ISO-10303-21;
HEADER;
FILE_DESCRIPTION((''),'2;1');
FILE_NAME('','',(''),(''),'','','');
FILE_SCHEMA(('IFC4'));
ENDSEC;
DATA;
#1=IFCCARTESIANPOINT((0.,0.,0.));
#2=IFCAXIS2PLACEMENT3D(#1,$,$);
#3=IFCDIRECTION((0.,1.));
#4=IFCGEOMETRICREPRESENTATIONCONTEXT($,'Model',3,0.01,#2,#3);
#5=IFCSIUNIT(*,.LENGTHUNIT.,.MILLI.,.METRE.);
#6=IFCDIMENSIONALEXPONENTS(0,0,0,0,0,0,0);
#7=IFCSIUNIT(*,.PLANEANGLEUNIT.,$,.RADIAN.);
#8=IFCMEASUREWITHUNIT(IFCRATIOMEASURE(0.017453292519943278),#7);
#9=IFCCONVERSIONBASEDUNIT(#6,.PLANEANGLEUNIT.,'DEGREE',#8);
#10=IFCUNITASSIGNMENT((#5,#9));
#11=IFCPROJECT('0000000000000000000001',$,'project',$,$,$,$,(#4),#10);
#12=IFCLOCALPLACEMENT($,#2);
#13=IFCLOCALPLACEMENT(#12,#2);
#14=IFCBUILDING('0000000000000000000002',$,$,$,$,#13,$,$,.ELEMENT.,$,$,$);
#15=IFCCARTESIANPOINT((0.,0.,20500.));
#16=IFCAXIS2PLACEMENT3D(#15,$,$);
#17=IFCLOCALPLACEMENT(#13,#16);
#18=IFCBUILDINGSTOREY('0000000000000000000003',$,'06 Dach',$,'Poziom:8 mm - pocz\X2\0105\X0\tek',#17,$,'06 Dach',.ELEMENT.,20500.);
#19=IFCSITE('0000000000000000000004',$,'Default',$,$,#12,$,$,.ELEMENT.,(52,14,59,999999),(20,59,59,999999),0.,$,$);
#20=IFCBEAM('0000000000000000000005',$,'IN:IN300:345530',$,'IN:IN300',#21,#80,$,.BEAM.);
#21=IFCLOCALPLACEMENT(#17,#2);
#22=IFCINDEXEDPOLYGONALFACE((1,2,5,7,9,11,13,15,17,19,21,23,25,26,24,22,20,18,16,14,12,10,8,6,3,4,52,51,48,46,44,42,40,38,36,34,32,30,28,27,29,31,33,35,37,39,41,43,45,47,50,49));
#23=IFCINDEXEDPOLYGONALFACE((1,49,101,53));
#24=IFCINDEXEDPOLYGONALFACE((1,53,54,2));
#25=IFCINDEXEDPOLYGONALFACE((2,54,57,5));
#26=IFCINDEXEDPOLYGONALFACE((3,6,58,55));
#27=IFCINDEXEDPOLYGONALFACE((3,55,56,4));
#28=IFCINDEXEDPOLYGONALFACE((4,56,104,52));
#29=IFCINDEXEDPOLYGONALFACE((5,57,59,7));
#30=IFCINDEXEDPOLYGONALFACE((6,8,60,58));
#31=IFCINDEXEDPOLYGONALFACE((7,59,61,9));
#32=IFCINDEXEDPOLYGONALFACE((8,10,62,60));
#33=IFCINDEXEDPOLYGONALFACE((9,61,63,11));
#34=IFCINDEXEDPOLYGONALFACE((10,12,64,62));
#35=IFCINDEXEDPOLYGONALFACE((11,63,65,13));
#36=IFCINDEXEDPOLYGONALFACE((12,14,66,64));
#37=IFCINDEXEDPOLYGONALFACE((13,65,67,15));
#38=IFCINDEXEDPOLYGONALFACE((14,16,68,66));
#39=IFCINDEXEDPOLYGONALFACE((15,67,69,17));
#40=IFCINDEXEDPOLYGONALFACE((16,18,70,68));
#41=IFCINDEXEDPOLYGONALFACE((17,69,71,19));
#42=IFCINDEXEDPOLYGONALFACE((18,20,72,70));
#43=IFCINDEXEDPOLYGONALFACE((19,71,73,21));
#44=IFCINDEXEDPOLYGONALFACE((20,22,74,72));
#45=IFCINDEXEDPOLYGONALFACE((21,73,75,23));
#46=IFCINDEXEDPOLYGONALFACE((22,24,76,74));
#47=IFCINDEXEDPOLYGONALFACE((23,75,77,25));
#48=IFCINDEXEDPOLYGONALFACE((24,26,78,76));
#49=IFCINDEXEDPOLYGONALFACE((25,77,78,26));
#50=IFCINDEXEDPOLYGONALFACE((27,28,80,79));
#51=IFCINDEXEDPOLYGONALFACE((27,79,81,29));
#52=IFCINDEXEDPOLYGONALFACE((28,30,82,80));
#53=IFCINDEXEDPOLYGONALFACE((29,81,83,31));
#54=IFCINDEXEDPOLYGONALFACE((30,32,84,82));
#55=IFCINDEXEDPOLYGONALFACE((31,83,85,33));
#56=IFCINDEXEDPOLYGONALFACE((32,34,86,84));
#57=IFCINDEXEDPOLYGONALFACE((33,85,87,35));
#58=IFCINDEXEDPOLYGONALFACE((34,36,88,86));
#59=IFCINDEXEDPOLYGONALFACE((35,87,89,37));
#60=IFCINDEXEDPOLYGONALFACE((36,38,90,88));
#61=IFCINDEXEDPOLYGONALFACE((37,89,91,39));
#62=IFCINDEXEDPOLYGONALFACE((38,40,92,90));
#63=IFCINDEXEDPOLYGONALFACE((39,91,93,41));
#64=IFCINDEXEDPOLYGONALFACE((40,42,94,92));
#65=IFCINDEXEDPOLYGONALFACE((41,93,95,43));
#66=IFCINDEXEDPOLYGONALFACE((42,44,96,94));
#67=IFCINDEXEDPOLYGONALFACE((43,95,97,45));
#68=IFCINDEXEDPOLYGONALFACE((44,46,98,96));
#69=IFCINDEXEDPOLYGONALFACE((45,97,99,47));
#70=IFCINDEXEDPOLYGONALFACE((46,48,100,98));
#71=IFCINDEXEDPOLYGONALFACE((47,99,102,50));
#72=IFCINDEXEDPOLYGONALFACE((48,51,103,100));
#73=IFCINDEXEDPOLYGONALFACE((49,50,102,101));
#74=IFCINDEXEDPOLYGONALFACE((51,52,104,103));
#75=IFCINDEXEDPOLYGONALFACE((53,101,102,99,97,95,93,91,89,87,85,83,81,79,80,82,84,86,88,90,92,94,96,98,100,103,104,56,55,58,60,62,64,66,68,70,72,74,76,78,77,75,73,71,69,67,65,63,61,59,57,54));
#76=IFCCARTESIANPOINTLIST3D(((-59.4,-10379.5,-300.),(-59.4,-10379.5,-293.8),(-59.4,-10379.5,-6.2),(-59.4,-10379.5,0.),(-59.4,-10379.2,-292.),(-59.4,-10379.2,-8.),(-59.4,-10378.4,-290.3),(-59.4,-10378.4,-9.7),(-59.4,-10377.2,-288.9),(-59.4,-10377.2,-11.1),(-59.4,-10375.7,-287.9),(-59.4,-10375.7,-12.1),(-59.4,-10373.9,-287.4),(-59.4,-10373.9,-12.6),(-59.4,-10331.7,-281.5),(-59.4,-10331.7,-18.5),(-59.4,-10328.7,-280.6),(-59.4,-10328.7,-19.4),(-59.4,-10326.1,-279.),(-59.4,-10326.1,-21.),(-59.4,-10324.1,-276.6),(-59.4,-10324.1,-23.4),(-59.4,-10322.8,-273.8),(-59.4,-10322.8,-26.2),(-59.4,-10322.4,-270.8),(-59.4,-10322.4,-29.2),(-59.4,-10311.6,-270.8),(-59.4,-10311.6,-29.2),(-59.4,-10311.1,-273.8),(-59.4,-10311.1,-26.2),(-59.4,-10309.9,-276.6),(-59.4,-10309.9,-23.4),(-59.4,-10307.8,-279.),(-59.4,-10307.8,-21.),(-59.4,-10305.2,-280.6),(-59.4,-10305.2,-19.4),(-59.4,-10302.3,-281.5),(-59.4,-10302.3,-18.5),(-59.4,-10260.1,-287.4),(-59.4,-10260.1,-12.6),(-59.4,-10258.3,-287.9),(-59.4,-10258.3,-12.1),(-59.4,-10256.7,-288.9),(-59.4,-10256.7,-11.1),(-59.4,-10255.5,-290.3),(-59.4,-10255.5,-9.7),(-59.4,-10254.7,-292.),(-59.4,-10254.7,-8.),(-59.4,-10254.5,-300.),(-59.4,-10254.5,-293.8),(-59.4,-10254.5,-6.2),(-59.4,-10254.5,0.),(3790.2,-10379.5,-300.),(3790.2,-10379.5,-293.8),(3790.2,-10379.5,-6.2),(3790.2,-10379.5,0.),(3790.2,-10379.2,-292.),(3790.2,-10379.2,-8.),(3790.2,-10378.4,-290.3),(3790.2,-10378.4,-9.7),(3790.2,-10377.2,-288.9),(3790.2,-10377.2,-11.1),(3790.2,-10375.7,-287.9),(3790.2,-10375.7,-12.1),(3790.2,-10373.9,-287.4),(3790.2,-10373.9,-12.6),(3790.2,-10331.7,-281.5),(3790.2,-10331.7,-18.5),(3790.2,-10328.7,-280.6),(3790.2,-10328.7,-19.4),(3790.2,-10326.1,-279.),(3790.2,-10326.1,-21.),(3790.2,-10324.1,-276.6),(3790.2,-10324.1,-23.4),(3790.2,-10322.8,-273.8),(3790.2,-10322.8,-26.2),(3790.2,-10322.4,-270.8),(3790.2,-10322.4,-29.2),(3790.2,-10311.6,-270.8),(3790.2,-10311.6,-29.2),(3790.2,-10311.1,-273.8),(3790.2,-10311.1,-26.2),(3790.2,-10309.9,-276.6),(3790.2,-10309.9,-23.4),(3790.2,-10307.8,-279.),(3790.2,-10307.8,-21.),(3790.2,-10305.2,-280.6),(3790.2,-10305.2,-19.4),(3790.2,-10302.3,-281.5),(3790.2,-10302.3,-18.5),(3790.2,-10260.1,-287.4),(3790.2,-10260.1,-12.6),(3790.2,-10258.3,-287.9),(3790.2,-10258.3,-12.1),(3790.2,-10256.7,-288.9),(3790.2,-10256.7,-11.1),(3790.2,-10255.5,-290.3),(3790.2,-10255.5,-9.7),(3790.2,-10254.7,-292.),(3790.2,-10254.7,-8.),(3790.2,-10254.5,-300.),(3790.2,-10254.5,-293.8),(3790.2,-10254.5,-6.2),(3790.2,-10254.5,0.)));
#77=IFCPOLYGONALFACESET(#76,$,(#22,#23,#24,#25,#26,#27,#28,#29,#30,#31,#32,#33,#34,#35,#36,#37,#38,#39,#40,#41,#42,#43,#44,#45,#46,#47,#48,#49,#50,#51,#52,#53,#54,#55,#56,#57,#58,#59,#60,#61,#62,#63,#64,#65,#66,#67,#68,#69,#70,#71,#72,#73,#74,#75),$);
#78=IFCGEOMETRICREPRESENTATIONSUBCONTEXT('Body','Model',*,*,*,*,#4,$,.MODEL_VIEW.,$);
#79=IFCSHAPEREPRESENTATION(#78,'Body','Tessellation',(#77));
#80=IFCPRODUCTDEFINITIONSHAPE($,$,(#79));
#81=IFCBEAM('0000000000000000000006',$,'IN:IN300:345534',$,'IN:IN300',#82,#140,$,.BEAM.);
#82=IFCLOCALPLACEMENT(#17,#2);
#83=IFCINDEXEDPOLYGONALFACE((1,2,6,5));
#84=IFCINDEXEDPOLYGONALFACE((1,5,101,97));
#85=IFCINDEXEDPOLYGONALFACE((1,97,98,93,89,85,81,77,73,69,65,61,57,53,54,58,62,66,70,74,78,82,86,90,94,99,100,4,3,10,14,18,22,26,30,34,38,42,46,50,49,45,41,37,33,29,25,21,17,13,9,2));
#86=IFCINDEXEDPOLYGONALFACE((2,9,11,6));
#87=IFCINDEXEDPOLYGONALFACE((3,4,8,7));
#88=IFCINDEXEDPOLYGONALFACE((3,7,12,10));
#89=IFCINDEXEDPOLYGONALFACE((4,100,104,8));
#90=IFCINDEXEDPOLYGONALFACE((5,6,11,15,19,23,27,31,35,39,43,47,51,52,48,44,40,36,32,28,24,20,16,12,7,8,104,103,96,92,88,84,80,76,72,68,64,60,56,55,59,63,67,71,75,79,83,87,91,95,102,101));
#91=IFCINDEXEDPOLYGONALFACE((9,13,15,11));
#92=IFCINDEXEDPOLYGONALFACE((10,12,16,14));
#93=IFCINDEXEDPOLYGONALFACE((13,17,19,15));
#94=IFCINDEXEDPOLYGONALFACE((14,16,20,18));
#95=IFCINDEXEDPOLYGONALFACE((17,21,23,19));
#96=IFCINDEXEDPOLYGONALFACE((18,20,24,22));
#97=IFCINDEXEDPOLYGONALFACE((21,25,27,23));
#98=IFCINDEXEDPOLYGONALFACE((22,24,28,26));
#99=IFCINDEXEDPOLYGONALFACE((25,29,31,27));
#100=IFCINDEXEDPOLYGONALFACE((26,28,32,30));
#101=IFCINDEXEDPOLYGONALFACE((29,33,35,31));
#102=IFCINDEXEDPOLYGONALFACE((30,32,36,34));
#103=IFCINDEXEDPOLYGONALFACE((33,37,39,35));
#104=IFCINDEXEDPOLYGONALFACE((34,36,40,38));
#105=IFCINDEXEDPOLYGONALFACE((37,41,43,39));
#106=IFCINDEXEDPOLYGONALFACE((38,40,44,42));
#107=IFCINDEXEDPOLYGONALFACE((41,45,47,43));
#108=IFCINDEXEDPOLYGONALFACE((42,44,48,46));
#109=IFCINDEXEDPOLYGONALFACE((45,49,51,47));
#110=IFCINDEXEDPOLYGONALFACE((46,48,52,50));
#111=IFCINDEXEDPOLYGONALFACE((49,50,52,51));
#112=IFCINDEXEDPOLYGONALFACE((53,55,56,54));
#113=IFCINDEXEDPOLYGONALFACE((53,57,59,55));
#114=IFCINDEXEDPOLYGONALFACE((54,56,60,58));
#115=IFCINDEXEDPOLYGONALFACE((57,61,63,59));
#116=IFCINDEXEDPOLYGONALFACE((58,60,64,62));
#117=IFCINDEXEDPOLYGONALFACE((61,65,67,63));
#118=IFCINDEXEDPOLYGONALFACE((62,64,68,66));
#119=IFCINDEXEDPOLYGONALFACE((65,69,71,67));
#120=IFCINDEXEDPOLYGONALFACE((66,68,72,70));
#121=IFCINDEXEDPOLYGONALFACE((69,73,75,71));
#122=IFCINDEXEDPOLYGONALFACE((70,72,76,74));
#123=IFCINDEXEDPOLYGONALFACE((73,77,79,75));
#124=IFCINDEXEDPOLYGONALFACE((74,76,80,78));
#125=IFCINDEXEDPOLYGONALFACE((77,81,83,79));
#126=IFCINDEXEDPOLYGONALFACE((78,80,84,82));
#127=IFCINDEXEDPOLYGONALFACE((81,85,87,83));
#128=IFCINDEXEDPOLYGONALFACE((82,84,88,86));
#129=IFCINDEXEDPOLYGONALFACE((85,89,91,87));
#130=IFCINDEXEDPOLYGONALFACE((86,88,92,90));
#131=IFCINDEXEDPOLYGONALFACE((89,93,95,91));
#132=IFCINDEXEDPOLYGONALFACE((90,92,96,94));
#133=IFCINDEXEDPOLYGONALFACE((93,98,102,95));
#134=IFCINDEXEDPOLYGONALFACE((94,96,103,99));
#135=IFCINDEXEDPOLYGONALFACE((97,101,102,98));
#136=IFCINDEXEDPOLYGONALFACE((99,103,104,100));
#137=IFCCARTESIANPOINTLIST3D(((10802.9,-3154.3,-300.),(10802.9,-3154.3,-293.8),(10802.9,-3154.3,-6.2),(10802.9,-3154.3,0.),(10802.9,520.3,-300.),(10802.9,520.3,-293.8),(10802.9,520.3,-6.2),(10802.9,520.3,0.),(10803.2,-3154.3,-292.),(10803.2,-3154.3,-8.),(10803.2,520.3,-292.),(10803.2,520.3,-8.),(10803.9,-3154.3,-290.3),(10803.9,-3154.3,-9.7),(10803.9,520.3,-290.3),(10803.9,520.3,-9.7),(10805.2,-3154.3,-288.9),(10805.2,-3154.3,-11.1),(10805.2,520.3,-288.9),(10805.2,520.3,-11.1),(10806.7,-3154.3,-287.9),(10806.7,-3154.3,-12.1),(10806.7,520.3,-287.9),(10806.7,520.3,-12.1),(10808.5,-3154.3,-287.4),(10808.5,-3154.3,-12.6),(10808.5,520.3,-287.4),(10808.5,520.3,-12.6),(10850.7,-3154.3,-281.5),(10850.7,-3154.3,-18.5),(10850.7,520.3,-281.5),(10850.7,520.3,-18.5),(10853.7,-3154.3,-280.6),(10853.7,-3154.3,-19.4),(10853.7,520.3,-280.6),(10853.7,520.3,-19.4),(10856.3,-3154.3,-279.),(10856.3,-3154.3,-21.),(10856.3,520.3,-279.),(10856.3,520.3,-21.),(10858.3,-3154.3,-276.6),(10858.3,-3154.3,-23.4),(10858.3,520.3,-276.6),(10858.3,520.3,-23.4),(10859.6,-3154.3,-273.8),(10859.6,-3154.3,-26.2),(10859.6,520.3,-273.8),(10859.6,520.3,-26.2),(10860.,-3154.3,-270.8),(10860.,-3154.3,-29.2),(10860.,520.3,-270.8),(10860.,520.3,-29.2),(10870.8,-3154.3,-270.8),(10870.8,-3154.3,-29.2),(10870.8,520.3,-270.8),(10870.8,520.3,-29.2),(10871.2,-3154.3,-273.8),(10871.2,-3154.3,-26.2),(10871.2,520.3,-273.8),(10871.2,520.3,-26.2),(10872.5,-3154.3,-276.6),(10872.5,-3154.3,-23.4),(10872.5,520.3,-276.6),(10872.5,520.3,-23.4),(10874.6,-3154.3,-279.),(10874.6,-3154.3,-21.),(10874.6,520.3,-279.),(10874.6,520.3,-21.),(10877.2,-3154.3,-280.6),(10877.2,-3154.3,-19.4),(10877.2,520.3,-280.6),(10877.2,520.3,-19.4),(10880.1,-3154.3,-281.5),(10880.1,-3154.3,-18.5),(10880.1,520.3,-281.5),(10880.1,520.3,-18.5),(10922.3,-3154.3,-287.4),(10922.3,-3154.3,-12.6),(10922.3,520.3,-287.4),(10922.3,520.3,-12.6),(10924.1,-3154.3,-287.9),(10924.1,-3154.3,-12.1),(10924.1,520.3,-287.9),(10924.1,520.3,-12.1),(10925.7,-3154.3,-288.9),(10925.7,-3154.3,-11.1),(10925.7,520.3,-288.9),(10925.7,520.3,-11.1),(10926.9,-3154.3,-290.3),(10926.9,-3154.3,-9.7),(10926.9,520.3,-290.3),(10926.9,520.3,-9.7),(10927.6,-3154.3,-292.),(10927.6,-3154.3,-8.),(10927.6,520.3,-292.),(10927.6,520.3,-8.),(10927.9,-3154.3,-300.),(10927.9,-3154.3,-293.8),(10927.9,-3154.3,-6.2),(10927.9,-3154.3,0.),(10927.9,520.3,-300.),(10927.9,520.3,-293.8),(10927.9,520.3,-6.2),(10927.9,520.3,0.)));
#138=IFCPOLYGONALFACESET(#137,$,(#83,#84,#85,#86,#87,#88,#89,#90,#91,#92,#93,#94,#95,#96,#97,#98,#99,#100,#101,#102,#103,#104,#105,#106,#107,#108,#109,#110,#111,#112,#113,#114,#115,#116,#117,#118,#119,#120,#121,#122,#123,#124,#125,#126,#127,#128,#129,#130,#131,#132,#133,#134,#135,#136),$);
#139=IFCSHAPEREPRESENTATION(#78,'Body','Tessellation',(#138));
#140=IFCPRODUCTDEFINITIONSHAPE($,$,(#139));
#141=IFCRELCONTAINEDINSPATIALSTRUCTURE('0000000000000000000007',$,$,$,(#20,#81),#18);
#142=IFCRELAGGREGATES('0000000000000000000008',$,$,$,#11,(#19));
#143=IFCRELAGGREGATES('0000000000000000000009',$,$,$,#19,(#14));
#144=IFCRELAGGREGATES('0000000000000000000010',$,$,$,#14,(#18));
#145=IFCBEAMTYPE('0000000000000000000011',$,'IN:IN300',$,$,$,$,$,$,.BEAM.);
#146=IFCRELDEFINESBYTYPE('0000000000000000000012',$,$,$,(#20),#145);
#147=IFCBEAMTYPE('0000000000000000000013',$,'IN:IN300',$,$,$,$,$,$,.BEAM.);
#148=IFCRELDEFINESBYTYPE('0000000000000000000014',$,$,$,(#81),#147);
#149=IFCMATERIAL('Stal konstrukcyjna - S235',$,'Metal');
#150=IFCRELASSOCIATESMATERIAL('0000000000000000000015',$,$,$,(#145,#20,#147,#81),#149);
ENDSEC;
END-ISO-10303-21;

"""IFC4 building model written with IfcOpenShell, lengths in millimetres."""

from ifc_helpers import new_model, entity, si_unit, converted_unit, direction, frame, origin, place, context, subcontext, project, spatial, line, arc, indexed_curve, outline, extrude, source, transform, mapped, material, type_object, type_shapes, element, save


model = new_model("IFC4")

# Units and contexts
model_context = context("Model", 3, precision=0.01, world=origin(), true_north=direction((0.0, 1.0)))
body_context = subcontext(model_context, "Body", "Model", "MODEL_VIEW")
ifc_project = project(units=[si_unit("LENGTHUNIT", "METRE", prefix="MILLI"), converted_unit("PLANEANGLEUNIT", "DEGREE", entity("IfcRatioMeasure", 0.017453292519943278), si_unit("PLANEANGLEUNIT", "RADIAN"), dimensions=[0, 0, 0, 0, 0, 0, 0])], contexts=[model_context])

# Site, building, storey
site_placement = place(None, origin())
site = spatial("IfcSite", under=ifc_project, at=site_placement, Name="Default", CompositionType="ELEMENT", RefLatitude=(52, 14, 59, 999999), RefLongitude=(20, 59, 59, 999999), RefElevation=0.0)
building_placement = place(site_placement, origin())
building = spatial("IfcBuilding", under=site, at=building_placement, CompositionType="ELEMENT")
storey_placement = place(building_placement, frame((0.0, 0.0, 20500.0)))
storey = spatial("IfcBuildingStorey", under=building, at=storey_placement, Name="06 Dach", ObjectType="Poziom:8 mm - początek", LongName="06 Dach", CompositionType="ELEMENT", Elevation=20500.0)

# Beams
ifc_material_1 = material(Name="Stal konstrukcyjna - S235", Category="Metal")
beam_type_1 = type_object("IfcBeamType", Name="IN:IN300", PredefinedType="BEAM", material=ifc_material_1)
shared_shape_1 = source(origin(), body_context, "Body", "SweptSolid", [
    extrude(outline(indexed_curve([(143.8, -62.5), (150.0, -62.5), (150.0, 62.5), (143.8, 62.5), (139.6, 60.9), (137.4, 56.9), (131.5, 14.7), (127.9, 8.1), (120.8, 5.4), (-120.8, 5.4), (-127.9, 8.1), (-131.5, 14.7), (-137.4, 56.9), (-139.6, 60.9), (-143.8, 62.5), (-150.0, 62.5), (-150.0, -62.5), (-143.8, -62.5), (-139.6, -60.9), (-137.4, -56.9), (-131.5, -14.7), (-127.9, -8.1), (-120.8, -5.4), (120.8, -5.4), (127.9, -8.1), (131.5, -14.7), (137.4, -56.9), (139.6, -60.9)], segments=[line(1, 2, 3, 4), arc(4, 5, 6), line(6, 7), arc(7, 8, 9), line(9, 10), arc(10, 11, 12), line(12, 13), arc(13, 14, 15), line(15, 16, 17, 18), arc(18, 19, 20), line(20, 21), arc(21, 22, 23), line(23, 24), arc(24, 25, 26), line(26, 27), arc(27, 28, 1)], self_intersect=False)), frame((-1924.8, 0.0, 0.0), z_axis=(1.0, 0.0, 0.0), x_axis=(0.0, 0.0, -1.0)), (0.0, 0.0, 1.0), 3849.6),
])
type_shapes(beam_type_1, [shared_shape_1])
for number, where, name in (
    (1, (1865.4, -10317.0, -150.0), "IN:IN300:345530"),
):
    element("IfcBeam", number, at=place(storey_placement, frame(where)), inside=storey, type_object=beam_type_1, material=ifc_material_1, Name=name, ObjectType="IN:IN300", PredefinedType="BEAM", context=body_context, shape_type="MappedRepresentation", body=[
        mapped(shared_shape_1, transform((0.0, 0.0, 0.0), scale=1.0)),
    ])
beam_type_2 = type_object("IfcBeamType", Name="IN:IN300", PredefinedType="BEAM", material=ifc_material_1)
shared_shape_2 = source(origin(), body_context, "Body", "SweptSolid", [
    extrude(outline(indexed_curve([(143.8, -62.5), (150.0, -62.5), (150.0, 62.5), (143.8, 62.5), (139.6, 60.9), (137.4, 56.9), (131.5, 14.7), (127.9, 8.1), (120.8, 5.4), (-120.8, 5.4), (-127.9, 8.1), (-131.5, 14.7), (-137.4, 56.9), (-139.6, 60.9), (-143.8, 62.5), (-150.0, 62.5), (-150.0, -62.5), (-143.8, -62.5), (-139.6, -60.9), (-137.4, -56.9), (-131.5, -14.7), (-127.9, -8.1), (-120.8, -5.4), (120.8, -5.4), (127.9, -8.1), (131.5, -14.7), (137.4, -56.9), (139.6, -60.9)], segments=[line(1, 2, 3, 4), arc(4, 5, 6), line(6, 7), arc(7, 8, 9), line(9, 10), arc(10, 11, 12), line(12, 13), arc(13, 14, 15), line(15, 16, 17, 18), arc(18, 19, 20), line(20, 21), arc(21, 22, 23), line(23, 24), arc(24, 25, 26), line(26, 27), arc(27, 28, 1)], self_intersect=False)), frame((-1837.3, 0.0, 0.0), z_axis=(1.0, 0.0, 0.0), x_axis=(0.0, 0.0, -1.0)), (0.0, 0.0, 1.0), 3674.6),
])
type_shapes(beam_type_2, [shared_shape_2])
for number, where, z_axis, x_axis, name in (
    (2, (10865.4, -1317.0, -150.0), (0.0, 0.0, 1.0), (0.0, -1.0, 0.0), "IN:IN300:345534"),
):
    element("IfcBeam", number, at=place(storey_placement, frame(where, z_axis=z_axis, x_axis=x_axis)), inside=storey, type_object=beam_type_2, material=ifc_material_1, Name=name, ObjectType="IN:IN300", PredefinedType="BEAM", context=body_context, shape_type="MappedRepresentation", body=[
        mapped(shared_shape_2, transform((0.0, 0.0, 0.0), scale=1.0)),
    ])

save(model, "model.ifc")
